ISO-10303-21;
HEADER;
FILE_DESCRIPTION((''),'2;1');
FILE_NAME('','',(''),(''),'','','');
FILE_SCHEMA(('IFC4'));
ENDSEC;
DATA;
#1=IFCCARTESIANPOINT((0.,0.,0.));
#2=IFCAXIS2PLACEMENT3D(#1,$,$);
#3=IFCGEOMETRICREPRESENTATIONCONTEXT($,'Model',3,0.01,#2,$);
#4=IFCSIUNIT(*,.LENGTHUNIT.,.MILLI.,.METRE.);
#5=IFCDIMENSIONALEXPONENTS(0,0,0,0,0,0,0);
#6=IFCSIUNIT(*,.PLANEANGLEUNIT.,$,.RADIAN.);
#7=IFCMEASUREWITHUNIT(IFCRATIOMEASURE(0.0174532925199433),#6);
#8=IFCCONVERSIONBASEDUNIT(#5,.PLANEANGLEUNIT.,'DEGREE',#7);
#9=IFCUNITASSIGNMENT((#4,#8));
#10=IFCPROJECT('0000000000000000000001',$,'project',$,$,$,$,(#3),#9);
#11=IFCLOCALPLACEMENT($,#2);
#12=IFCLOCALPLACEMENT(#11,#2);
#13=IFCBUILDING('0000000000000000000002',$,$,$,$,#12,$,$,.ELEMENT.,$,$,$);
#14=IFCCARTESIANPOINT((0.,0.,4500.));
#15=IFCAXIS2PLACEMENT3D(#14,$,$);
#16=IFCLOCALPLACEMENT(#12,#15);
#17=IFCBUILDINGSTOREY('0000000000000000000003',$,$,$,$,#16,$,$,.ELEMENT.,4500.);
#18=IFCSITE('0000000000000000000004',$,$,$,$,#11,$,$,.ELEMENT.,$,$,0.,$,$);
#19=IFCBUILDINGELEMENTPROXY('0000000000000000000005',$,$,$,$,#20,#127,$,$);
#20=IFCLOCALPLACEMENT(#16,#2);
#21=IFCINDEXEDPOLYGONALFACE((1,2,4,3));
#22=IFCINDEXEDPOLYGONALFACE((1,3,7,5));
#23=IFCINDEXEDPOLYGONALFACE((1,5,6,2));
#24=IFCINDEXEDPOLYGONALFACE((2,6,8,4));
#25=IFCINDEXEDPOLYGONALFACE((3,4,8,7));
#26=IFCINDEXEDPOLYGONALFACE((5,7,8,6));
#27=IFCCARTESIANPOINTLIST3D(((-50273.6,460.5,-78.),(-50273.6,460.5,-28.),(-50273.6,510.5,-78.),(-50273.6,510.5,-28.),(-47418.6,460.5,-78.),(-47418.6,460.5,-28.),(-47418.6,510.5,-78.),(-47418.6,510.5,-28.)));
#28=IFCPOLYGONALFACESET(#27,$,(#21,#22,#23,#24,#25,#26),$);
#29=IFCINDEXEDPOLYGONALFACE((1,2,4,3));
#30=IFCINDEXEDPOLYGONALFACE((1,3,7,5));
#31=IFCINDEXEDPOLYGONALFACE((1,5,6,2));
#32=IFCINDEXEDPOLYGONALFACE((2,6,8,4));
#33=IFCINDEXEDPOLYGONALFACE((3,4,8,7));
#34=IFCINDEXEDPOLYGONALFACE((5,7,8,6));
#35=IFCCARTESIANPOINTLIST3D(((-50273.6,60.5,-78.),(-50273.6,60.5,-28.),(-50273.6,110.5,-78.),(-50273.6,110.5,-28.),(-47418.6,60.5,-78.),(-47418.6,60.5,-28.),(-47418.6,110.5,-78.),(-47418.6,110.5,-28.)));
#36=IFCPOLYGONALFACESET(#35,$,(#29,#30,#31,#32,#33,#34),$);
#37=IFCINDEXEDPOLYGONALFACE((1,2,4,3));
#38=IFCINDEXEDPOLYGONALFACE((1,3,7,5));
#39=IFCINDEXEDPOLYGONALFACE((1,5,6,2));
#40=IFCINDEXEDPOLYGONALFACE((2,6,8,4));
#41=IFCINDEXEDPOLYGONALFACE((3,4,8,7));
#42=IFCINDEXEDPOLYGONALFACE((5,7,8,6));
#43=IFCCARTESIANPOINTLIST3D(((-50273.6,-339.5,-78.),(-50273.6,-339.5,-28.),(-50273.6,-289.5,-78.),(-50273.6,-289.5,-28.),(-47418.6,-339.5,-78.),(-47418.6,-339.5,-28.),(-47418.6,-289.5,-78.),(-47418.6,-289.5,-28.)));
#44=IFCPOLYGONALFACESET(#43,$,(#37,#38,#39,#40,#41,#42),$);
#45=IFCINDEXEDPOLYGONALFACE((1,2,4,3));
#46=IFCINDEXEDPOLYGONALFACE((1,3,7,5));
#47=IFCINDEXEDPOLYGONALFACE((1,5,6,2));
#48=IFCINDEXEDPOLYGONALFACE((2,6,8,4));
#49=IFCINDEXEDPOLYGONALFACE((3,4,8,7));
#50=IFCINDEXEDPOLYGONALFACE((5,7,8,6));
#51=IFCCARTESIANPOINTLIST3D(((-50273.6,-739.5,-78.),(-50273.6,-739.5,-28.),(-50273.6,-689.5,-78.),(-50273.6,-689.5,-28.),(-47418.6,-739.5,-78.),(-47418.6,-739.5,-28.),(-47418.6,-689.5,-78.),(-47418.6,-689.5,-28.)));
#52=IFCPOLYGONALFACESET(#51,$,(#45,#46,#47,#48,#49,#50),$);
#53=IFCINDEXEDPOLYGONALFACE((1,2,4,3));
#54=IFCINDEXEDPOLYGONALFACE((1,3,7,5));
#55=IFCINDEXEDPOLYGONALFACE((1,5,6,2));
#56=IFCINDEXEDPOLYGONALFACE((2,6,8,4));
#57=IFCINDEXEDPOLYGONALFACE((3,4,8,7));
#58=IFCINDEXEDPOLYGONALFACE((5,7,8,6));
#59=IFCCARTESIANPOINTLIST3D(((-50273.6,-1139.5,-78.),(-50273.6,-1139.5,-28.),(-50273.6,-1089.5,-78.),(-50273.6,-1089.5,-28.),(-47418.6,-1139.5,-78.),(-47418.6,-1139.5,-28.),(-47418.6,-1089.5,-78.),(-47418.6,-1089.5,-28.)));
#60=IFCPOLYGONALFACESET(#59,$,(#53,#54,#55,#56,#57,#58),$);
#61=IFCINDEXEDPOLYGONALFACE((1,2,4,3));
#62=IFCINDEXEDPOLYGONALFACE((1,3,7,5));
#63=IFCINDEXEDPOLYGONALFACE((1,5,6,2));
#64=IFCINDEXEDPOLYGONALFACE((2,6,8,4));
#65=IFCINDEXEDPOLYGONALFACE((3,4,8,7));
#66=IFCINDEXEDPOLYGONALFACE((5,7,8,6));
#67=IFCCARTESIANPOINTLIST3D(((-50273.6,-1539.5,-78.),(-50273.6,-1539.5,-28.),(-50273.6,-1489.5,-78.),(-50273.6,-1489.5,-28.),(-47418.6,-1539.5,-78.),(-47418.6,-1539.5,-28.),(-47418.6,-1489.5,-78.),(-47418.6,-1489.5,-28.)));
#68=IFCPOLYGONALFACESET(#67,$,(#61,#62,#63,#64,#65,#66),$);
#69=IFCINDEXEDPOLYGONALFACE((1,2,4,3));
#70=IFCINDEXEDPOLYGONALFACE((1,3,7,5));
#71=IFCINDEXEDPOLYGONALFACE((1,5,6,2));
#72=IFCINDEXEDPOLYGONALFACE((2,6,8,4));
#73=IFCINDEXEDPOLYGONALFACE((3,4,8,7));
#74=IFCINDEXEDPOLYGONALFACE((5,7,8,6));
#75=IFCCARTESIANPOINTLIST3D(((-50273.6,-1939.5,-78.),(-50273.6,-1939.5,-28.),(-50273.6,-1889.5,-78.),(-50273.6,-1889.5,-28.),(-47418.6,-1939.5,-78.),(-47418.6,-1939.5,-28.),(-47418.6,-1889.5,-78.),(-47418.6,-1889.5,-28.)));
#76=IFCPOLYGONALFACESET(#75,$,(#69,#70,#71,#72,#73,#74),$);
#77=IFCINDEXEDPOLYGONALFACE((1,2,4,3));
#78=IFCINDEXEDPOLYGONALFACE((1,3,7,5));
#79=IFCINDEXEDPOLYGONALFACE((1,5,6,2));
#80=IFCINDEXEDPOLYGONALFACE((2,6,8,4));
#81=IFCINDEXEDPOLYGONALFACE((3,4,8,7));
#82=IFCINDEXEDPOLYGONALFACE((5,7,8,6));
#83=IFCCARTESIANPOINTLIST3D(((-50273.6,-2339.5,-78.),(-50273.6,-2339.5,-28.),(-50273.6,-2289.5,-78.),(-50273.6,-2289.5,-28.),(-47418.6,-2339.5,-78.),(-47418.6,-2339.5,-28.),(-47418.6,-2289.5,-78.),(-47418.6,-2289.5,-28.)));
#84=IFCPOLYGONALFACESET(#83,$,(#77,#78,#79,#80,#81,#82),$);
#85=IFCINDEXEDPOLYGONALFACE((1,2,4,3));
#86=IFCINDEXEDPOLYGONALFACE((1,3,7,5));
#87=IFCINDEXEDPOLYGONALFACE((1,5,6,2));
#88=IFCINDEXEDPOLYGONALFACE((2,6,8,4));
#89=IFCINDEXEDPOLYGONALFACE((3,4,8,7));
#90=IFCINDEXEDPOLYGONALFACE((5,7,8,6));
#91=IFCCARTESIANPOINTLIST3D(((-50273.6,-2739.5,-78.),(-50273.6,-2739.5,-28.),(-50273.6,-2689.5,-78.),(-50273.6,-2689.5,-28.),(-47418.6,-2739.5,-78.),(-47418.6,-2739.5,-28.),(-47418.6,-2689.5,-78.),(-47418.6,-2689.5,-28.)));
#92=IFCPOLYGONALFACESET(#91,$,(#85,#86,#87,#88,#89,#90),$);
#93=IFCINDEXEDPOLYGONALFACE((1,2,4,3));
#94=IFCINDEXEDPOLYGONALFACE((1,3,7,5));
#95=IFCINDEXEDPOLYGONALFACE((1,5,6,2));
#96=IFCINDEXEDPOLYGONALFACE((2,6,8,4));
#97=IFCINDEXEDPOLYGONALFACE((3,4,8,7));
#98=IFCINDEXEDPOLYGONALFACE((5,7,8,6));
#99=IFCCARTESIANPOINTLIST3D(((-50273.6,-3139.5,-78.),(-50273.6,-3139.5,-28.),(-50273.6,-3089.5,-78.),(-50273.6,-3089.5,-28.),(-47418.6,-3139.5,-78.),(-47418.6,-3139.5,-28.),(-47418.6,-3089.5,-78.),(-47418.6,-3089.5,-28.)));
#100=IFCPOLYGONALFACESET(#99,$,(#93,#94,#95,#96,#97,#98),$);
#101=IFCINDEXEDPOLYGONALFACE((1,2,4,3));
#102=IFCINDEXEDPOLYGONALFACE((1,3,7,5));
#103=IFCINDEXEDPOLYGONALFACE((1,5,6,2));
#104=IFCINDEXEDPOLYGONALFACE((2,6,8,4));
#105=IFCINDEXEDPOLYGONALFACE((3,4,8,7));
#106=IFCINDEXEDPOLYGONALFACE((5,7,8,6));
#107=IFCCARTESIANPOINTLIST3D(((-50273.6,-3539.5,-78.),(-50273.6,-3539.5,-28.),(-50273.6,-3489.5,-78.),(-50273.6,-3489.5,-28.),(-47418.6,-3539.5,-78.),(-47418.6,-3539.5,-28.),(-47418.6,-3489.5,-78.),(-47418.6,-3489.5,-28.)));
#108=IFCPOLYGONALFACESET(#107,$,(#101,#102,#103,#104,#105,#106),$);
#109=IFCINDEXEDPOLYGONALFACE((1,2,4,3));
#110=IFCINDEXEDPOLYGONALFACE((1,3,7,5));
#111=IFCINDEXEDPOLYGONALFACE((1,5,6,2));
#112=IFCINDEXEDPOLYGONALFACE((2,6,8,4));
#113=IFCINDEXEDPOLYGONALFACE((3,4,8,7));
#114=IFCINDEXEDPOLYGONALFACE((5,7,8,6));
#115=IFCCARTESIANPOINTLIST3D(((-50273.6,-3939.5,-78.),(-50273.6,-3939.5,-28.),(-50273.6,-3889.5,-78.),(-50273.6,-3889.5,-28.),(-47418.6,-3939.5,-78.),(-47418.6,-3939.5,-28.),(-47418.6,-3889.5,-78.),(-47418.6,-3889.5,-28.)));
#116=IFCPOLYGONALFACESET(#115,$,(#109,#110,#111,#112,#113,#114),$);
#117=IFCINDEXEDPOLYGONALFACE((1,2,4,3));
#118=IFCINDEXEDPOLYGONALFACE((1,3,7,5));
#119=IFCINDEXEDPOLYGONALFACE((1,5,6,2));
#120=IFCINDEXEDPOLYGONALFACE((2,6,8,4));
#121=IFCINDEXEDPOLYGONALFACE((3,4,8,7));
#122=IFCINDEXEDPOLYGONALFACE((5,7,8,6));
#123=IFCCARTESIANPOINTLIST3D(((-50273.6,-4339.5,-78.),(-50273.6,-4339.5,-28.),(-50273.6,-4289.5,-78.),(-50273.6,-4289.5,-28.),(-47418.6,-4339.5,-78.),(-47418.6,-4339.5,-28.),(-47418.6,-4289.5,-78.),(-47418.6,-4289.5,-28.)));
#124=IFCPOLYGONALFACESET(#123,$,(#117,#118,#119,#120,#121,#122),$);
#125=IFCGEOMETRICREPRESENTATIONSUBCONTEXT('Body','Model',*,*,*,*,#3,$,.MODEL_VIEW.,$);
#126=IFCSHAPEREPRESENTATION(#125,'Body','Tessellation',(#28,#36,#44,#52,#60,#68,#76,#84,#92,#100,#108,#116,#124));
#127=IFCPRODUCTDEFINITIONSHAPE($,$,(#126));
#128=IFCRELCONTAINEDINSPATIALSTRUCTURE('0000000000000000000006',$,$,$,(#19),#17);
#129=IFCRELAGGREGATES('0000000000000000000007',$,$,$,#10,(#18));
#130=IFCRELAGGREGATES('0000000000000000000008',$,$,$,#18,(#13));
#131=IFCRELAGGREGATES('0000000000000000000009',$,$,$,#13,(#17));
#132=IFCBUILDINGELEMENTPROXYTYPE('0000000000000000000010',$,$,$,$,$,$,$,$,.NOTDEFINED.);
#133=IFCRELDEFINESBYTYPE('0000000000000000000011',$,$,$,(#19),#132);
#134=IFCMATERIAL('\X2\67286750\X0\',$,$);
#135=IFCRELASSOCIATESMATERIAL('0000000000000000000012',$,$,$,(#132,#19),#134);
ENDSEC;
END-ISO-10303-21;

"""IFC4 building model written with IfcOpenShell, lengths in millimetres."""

from ifc_helpers import new_model, entity, si_unit, converted_unit, frame, frame_2d, origin, origin_2d_with_axis, place, context, subcontext, project, spatial, rectangle, extrude, source, transform, mapped, material, type_object, type_shapes, element, save


model = new_model("IFC4")

# Units and contexts
model_context = context("Model", 3, precision=0.01, world=origin())
body_context = subcontext(model_context, "Body", "Model", "MODEL_VIEW")
ifc_project = project(units=[si_unit("LENGTHUNIT", "METRE", prefix="MILLI"), converted_unit("PLANEANGLEUNIT", "DEGREE", entity("IfcRatioMeasure", 0.0174532925199433), si_unit("PLANEANGLEUNIT", "RADIAN"), dimensions=[0, 0, 0, 0, 0, 0, 0])], contexts=[model_context])

# Site, building, storey
site_placement = place(None, origin())
site = spatial("IfcSite", under=ifc_project, at=site_placement, CompositionType="ELEMENT", RefElevation=0.0)
building_placement = place(site_placement, origin())
building = spatial("IfcBuilding", under=site, at=building_placement, CompositionType="ELEMENT")
storey_placement = place(building_placement, frame((0.0, 0.0, 4500.0)))
storey = spatial("IfcBuildingStorey", under=building, at=storey_placement, CompositionType="ELEMENT", Elevation=4500.0)

# Building element proxy
ifc_material_1 = material(Name="木材")
building_element_proxy_type_1 = type_object("IfcBuildingElementProxyType", PredefinedType="NOTDEFINED", material=ifc_material_1)
shared_shape_1 = source(origin(), body_context, "Body", "SweptSolid", [
    extrude(rectangle(XDim=2855.0, YDim=50.0, at=origin_2d_with_axis()), frame((1427.5, 4825.0, 0.0), z_axis=(0.0, 0.0, 1.0), x_axis=(-1.0, 0.0, 0.0)), (0.0, 0.0, 1.0), 50.0),
    extrude(rectangle(XDim=2855.0, YDim=50.0, at=origin_2d_with_axis()), frame((1427.5, 4425.0, 0.0), z_axis=(0.0, 0.0, 1.0), x_axis=(-1.0, 0.0, 0.0)), (0.0, 0.0, 1.0), 50.0),
    extrude(rectangle(XDim=2855.0, YDim=50.0, at=origin_2d_with_axis()), frame((1427.5, 4025.0, 0.0), z_axis=(0.0, 0.0, 1.0), x_axis=(-1.0, 0.0, 0.0)), (0.0, 0.0, 1.0), 50.0),
    extrude(rectangle(XDim=2855.0, YDim=50.0, at=frame_2d((0.0, 0.0), x_axis=(1.0, 0.0))), frame((1427.5, 3625.0, 0.0), z_axis=(0.0, 0.0, 1.0), x_axis=(-1.0, 0.0, 0.0)), (0.0, 0.0, 1.0), 50.0),
    extrude(rectangle(XDim=2855.0, YDim=50.0, at=origin_2d_with_axis()), frame((1427.5, 3225.0, 0.0), z_axis=(0.0, 0.0, 1.0), x_axis=(-1.0, 0.0, 0.0)), (0.0, 0.0, 1.0), 50.0),
    extrude(rectangle(XDim=2855.0, YDim=50.0, at=origin_2d_with_axis()), frame((1427.5, 2825.0, 0.0), z_axis=(0.0, 0.0, 1.0), x_axis=(-1.0, 0.0, 0.0)), (0.0, 0.0, 1.0), 50.0),
    extrude(rectangle(XDim=2855.0, YDim=50.0, at=origin_2d_with_axis()), frame((1427.5, 2425.0, 0.0), z_axis=(0.0, 0.0, 1.0), x_axis=(-1.0, 0.0, 0.0)), (0.0, 0.0, 1.0), 50.0),
    extrude(rectangle(XDim=2855.0, YDim=50.0, at=origin_2d_with_axis()), frame((1427.5, 2025.0, 0.0), z_axis=(0.0, 0.0, 1.0), x_axis=(-1.0, 0.0, 0.0)), (0.0, 0.0, 1.0), 50.0),
    extrude(rectangle(XDim=2855.0, YDim=50.0, at=origin_2d_with_axis()), frame((1427.5, 1625.0, 0.0), z_axis=(0.0, 0.0, 1.0), x_axis=(-1.0, 0.0, 0.0)), (0.0, 0.0, 1.0), 50.0),
    extrude(rectangle(XDim=2855.0, YDim=50.0, at=origin_2d_with_axis()), frame((1427.5, 1225.0, 0.0), z_axis=(0.0, 0.0, 1.0), x_axis=(-1.0, 0.0, 0.0)), (0.0, 0.0, 1.0), 50.0),
    extrude(rectangle(XDim=2855.0, YDim=50.0, at=origin_2d_with_axis()), frame((1427.5, 825.0, 0.0), z_axis=(0.0, 0.0, 1.0), x_axis=(-1.0, 0.0, 0.0)), (0.0, 0.0, 1.0), 50.0),
    extrude(rectangle(XDim=2855.0, YDim=50.0, at=origin_2d_with_axis()), frame((1427.5, 425.0, 0.0), z_axis=(0.0, 0.0, 1.0), x_axis=(-1.0, 0.0, 0.0)), (0.0, 0.0, 1.0), 50.0),
    extrude(rectangle(XDim=2855.0, YDim=50.0, at=origin_2d_with_axis()), frame((1427.5, 25.0, 0.0), z_axis=(0.0, 0.0, 1.0), x_axis=(-1.0, 0.0, 0.0)), (0.0, 0.0, 1.0), 50.0),
])
type_shapes(building_element_proxy_type_1, [shared_shape_1])
proxy_1_placement = place(storey_placement, frame((-50273.6, -4339.5, -78.0)))
element("IfcBuildingElementProxy", 1, at=proxy_1_placement, inside=storey, type_object=building_element_proxy_type_1, material=ifc_material_1, context=body_context, shape_type="MappedRepresentation", body=[
    mapped(shared_shape_1, transform((0.0, 0.0, 0.0), scale=1.0)),
])

save(model, "model.ifc")
